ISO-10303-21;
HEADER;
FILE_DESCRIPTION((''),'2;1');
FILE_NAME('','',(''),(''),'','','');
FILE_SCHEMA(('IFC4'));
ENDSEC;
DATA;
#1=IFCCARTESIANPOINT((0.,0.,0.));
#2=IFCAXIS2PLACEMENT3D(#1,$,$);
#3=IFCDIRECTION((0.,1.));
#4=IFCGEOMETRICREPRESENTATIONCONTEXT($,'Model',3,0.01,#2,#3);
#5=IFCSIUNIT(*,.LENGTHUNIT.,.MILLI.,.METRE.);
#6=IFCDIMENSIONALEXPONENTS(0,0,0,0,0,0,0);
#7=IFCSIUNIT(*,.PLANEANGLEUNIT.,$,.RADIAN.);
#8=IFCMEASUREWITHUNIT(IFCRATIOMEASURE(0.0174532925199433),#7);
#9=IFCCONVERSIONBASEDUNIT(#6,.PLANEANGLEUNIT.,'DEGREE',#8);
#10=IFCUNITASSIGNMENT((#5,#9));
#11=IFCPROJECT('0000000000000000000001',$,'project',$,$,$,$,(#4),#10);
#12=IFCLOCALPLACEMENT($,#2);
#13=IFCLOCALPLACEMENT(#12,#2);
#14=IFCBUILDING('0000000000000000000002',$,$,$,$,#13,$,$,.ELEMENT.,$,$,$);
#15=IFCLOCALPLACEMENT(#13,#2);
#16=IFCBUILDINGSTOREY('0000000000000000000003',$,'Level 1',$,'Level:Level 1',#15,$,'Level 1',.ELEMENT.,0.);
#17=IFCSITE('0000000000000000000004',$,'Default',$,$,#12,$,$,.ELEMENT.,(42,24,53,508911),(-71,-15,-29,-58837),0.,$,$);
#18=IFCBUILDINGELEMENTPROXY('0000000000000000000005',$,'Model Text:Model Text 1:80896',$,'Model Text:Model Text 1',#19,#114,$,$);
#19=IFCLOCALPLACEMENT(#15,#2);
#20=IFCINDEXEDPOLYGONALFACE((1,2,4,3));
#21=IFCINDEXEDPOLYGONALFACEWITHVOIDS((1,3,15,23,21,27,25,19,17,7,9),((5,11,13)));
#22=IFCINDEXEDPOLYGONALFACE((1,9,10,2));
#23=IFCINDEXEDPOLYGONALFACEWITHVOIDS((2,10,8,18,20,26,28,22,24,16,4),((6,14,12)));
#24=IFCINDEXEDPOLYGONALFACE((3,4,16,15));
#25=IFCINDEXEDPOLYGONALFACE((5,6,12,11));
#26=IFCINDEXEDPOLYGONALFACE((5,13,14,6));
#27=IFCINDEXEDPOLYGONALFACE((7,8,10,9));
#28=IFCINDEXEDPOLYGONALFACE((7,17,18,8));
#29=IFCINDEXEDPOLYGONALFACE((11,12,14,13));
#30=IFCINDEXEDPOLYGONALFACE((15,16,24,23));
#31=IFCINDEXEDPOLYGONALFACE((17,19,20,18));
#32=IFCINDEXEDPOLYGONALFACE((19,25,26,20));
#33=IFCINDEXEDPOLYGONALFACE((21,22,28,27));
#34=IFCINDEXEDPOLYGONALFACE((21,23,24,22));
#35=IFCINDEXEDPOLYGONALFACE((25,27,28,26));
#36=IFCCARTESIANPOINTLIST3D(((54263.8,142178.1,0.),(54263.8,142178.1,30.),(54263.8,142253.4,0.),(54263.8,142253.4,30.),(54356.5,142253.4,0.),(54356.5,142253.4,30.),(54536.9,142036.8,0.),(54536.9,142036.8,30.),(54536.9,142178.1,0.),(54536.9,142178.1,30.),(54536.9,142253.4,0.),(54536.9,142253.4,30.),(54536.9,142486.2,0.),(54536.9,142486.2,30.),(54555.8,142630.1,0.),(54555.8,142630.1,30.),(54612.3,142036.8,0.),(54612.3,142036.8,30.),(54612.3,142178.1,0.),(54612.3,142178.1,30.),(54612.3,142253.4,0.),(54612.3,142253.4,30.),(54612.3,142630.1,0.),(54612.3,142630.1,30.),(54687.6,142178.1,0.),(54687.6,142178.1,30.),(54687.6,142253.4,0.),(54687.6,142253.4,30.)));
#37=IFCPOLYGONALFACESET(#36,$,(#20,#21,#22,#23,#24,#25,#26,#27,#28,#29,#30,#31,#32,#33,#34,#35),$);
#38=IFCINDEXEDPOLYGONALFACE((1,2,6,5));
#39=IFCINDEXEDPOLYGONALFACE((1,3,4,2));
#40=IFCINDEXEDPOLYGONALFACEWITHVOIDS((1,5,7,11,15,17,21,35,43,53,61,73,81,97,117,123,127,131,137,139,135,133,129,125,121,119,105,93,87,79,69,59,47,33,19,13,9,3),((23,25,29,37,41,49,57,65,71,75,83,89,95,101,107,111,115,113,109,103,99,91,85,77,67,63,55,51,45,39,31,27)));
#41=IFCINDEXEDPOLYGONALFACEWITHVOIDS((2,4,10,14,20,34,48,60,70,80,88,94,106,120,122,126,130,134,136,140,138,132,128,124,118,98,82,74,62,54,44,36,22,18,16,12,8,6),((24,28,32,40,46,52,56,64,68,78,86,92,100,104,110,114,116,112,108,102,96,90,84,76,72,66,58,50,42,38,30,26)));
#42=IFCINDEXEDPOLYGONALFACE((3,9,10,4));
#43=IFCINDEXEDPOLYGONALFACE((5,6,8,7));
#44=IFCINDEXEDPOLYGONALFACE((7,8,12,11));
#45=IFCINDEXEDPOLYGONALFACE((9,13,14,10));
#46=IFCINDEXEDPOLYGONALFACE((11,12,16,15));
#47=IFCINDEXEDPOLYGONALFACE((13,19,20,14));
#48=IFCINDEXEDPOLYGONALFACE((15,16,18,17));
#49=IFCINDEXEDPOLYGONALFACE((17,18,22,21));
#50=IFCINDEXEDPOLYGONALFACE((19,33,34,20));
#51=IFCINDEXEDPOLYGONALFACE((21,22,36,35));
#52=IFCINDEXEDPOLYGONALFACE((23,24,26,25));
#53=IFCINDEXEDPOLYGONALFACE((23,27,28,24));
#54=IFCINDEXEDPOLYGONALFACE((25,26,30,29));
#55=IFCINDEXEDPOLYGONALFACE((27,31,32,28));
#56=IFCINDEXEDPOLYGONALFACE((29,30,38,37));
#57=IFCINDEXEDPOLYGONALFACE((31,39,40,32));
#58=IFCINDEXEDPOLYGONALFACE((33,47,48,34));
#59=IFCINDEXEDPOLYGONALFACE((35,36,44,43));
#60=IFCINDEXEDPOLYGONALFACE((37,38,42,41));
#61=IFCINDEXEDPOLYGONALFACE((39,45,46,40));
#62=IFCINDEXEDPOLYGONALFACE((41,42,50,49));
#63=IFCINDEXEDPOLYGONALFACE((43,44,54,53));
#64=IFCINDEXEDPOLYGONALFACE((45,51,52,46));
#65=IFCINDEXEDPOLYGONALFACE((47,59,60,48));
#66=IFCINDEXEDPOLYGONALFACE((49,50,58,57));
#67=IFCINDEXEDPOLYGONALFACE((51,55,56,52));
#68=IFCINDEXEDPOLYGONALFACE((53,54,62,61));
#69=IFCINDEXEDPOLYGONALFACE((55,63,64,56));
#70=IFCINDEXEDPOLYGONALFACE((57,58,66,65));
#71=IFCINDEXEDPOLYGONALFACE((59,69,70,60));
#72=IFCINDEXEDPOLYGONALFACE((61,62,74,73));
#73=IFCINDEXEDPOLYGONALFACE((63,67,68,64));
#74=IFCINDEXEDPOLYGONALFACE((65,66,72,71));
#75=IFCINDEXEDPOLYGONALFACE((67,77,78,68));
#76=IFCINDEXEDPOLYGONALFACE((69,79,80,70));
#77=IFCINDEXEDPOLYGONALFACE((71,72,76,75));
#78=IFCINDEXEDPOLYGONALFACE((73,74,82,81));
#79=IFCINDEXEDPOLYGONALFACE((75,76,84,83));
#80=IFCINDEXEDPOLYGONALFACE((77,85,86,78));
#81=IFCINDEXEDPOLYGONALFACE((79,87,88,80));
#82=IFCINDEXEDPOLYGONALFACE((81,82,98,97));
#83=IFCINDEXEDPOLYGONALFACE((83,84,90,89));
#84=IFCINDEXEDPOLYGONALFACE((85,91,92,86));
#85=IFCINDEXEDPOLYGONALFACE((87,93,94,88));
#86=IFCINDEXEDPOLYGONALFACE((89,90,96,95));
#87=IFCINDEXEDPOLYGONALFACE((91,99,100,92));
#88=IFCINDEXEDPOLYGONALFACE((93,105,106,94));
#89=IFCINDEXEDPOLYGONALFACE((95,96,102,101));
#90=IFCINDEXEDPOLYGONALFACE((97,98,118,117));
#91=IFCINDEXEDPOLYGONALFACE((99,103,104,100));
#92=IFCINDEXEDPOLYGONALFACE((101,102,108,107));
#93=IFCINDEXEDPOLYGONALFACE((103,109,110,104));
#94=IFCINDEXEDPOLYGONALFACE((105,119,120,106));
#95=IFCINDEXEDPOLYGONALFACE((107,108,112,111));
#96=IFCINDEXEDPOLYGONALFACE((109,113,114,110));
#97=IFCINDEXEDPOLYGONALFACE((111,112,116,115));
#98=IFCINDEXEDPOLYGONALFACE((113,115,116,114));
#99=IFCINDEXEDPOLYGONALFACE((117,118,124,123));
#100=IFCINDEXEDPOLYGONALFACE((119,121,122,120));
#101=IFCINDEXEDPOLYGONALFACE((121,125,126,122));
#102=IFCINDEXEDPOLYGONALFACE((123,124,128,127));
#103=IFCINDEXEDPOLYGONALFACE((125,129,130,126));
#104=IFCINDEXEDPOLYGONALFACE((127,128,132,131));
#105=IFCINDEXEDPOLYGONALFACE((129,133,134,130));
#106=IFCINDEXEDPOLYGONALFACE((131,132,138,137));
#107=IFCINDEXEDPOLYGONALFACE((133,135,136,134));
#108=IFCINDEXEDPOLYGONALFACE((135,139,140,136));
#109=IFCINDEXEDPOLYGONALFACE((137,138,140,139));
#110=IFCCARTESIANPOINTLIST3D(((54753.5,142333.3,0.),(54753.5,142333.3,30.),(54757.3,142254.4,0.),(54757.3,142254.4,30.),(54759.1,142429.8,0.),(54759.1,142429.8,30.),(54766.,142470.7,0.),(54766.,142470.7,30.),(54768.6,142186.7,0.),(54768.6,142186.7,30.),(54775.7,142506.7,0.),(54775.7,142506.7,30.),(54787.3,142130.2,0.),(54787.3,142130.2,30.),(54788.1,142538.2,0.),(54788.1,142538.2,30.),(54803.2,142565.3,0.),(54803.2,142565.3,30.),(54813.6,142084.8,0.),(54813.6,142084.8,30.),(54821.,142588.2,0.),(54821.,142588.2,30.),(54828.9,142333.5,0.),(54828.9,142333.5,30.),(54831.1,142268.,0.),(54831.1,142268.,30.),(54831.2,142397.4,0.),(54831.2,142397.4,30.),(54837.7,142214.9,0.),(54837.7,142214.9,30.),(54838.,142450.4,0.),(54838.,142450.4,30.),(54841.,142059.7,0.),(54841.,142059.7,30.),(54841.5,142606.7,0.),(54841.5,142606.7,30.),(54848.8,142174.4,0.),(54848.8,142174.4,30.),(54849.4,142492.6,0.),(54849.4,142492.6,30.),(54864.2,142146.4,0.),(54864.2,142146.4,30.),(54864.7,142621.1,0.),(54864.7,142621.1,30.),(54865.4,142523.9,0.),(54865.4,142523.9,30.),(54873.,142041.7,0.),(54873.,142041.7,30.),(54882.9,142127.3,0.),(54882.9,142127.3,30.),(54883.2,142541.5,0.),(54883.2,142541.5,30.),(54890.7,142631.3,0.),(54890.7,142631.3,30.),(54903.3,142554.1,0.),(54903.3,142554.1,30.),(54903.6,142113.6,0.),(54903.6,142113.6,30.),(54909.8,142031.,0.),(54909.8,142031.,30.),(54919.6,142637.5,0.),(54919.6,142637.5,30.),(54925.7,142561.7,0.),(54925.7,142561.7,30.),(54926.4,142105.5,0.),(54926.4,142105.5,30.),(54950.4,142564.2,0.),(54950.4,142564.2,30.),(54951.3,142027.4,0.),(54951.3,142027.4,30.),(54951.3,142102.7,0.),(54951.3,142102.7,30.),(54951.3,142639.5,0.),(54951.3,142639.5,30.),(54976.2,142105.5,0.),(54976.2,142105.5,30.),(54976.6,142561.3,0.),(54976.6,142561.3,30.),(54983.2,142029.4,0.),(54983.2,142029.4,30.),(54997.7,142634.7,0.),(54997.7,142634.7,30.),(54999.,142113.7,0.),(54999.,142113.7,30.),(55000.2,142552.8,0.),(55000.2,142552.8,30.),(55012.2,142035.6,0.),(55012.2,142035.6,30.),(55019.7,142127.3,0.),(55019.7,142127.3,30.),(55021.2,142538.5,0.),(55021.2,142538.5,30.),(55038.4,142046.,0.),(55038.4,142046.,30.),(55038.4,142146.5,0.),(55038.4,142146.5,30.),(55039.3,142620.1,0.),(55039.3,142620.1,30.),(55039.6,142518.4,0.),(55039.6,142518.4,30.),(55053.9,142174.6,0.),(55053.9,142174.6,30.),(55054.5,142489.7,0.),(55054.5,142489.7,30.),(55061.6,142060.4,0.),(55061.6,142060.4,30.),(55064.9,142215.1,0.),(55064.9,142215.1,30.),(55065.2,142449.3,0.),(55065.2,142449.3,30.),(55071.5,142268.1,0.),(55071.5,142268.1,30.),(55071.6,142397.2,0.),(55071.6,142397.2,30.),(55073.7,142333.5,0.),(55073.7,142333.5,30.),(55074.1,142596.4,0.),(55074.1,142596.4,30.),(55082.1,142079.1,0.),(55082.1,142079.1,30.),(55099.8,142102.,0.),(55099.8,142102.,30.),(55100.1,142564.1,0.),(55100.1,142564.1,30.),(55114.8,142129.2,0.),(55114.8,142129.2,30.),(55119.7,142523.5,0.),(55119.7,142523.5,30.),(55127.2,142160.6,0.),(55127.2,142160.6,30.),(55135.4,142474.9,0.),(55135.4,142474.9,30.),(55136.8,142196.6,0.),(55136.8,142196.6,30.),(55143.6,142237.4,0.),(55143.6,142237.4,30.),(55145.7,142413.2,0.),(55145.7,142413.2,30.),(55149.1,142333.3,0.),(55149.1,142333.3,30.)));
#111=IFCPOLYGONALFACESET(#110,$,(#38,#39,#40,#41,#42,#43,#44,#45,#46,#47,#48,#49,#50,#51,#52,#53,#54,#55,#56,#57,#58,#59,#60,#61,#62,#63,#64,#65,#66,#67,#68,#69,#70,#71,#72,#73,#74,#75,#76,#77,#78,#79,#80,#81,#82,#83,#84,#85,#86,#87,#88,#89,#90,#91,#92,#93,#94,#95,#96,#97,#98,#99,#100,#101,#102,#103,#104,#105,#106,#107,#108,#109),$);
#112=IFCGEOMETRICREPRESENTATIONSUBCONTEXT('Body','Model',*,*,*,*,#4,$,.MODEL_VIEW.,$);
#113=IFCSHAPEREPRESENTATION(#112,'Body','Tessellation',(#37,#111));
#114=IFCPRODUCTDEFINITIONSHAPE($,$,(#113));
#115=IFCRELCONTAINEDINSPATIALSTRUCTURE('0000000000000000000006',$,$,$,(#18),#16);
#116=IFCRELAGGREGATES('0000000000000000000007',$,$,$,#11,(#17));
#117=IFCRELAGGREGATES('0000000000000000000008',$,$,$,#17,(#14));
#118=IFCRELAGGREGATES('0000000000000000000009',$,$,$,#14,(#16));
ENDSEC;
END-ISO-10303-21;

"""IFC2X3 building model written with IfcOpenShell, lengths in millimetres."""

from ifc_helpers import new_model, entity, si_unit, converted_unit, direction, frame, origin, place, context, subcontext, project, spatial, polyline, outline, extrude, element, save


model = new_model("IFC2X3")

# Units and contexts
model_context = context("Model", 3, precision=0.01, world=origin(), true_north=direction((0.0, 1.0)))
body_context = subcontext(model_context, "Body", "Model", "MODEL_VIEW")
ifc_project = project(units=[si_unit("LENGTHUNIT", "METRE", prefix="MILLI"), converted_unit("PLANEANGLEUNIT", "DEGREE", entity("IfcRatioMeasure", 0.0174532925199433), si_unit("PLANEANGLEUNIT", "RADIAN"), dimensions=[0, 0, 0, 0, 0, 0, 0])], contexts=[model_context])

# Site, building, storey
site_placement = place(None, origin())
site = spatial("IfcSite", under=ifc_project, at=site_placement, Name="Default", CompositionType="ELEMENT", RefLatitude=(42, 24, 53, 508911), RefLongitude=(-71, -15, -29, -58837), RefElevation=0.0)
building_placement = place(site_placement, origin())
building = spatial("IfcBuilding", under=site, at=building_placement, CompositionType="ELEMENT")
storey_placement = place(building_placement, origin())
storey = spatial("IfcBuildingStorey", under=building, at=storey_placement, Name="Level 1", ObjectType="Level:Level 1", LongName="Level 1", CompositionType="ELEMENT", Elevation=0.0)

# Building element proxy
proxy_1_placement = place(storey_placement, origin())
element("IfcBuildingElementProxy", 1, at=proxy_1_placement, inside=storey, Name="Model Text:Model Text 1:80896", ObjectType="Model Text:Model Text 1", context=body_context, shape_type="SweptSolid", body=[
    extrude(outline(polyline([(-6.8, -218.3), (68.5, -218.3), (68.5, -77.1), (143.8, -77.1), (143.8, -1.7), (68.5, -1.7), (68.5, 375.0), (12.0, 375.0), (-280.0, -1.7), (-280.0, -77.1), (-6.8, -77.1), (-6.8, -218.3)]), holes=[polyline([(-6.8, -1.7), (-187.3, -1.7), (-6.8, 231.1), (-6.8, -1.7)])]), frame((54543.8, 142255.1, 0.0)), (0.0, 0.0, 1.0), 30.0),
    extrude(outline(polyline([(-10.6, -198.7), (68.3, -198.7), (136.5, -190.7), (193.9, -174.7), (240.5, -150.6), (266.9, -124.4), (286.3, -93.2), (298.8, -57.0), (304.3, -15.7), (303.8, 16.2), (299.0, 45.5), (289.9, 72.1), (276.6, 96.0), (258.9, 117.3), (236.9, 136.2), (210.4, 152.5), (179.6, 166.3), (144.1, 177.6), (103.7, 186.3), (8.2, 196.4), (-71.8, 196.7), (-134.0, 189.4), (-183.3, 176.1), (-224.7, 158.4), (-258.2, 133.9), (-283.5, 100.3), (-300.1, 59.5), (-307.1, 13.4), (-306.6, -18.4), (-301.8, -47.5), (-292.8, -74.0), (-279.6, -97.9), (-262.0, -119.2), (-240.0, -138.1), (-213.6, -154.5), (-182.8, -168.4), (-147.3, -179.8), (-106.7, -188.6), (-10.6, -198.7)]), holes=[polyline([(-7.2, -123.5), (-71.0, -118.2), (-123.6, -108.8), (-165.2, -95.4), (-195.7, -78.0), (-212.4, -59.4), (-224.1, -38.7), (-230.6, -15.9), (-231.9, 8.9), (-227.8, 35.0), (-218.1, 58.1), (-202.8, 78.4), (-182.0, 95.8), (-152.6, 109.4), (-111.7, 118.1), (-59.4, 122.0), (4.4, 121.1), (69.6, 115.8), (122.2, 106.7), (162.2, 93.7), (189.5, 77.0), (207.7, 57.4), (220.4, 36.0), (227.5, 12.8), (229.1, -12.1), (225.2, -36.8), (215.9, -59.2), (201.3, -79.3), (181.4, -97.1), (152.6, -111.2), (111.6, -120.3), (58.3, -124.4), (-7.2, -123.5)])]), frame((54952.6, 142332.1, 0.0), z_axis=(0.0, 0.0, 1.0), x_axis=(0.047515, -0.998871, 0.0)), (0.0, 0.0, 1.0), 30.0),
])

save(model, "model.ifc")
